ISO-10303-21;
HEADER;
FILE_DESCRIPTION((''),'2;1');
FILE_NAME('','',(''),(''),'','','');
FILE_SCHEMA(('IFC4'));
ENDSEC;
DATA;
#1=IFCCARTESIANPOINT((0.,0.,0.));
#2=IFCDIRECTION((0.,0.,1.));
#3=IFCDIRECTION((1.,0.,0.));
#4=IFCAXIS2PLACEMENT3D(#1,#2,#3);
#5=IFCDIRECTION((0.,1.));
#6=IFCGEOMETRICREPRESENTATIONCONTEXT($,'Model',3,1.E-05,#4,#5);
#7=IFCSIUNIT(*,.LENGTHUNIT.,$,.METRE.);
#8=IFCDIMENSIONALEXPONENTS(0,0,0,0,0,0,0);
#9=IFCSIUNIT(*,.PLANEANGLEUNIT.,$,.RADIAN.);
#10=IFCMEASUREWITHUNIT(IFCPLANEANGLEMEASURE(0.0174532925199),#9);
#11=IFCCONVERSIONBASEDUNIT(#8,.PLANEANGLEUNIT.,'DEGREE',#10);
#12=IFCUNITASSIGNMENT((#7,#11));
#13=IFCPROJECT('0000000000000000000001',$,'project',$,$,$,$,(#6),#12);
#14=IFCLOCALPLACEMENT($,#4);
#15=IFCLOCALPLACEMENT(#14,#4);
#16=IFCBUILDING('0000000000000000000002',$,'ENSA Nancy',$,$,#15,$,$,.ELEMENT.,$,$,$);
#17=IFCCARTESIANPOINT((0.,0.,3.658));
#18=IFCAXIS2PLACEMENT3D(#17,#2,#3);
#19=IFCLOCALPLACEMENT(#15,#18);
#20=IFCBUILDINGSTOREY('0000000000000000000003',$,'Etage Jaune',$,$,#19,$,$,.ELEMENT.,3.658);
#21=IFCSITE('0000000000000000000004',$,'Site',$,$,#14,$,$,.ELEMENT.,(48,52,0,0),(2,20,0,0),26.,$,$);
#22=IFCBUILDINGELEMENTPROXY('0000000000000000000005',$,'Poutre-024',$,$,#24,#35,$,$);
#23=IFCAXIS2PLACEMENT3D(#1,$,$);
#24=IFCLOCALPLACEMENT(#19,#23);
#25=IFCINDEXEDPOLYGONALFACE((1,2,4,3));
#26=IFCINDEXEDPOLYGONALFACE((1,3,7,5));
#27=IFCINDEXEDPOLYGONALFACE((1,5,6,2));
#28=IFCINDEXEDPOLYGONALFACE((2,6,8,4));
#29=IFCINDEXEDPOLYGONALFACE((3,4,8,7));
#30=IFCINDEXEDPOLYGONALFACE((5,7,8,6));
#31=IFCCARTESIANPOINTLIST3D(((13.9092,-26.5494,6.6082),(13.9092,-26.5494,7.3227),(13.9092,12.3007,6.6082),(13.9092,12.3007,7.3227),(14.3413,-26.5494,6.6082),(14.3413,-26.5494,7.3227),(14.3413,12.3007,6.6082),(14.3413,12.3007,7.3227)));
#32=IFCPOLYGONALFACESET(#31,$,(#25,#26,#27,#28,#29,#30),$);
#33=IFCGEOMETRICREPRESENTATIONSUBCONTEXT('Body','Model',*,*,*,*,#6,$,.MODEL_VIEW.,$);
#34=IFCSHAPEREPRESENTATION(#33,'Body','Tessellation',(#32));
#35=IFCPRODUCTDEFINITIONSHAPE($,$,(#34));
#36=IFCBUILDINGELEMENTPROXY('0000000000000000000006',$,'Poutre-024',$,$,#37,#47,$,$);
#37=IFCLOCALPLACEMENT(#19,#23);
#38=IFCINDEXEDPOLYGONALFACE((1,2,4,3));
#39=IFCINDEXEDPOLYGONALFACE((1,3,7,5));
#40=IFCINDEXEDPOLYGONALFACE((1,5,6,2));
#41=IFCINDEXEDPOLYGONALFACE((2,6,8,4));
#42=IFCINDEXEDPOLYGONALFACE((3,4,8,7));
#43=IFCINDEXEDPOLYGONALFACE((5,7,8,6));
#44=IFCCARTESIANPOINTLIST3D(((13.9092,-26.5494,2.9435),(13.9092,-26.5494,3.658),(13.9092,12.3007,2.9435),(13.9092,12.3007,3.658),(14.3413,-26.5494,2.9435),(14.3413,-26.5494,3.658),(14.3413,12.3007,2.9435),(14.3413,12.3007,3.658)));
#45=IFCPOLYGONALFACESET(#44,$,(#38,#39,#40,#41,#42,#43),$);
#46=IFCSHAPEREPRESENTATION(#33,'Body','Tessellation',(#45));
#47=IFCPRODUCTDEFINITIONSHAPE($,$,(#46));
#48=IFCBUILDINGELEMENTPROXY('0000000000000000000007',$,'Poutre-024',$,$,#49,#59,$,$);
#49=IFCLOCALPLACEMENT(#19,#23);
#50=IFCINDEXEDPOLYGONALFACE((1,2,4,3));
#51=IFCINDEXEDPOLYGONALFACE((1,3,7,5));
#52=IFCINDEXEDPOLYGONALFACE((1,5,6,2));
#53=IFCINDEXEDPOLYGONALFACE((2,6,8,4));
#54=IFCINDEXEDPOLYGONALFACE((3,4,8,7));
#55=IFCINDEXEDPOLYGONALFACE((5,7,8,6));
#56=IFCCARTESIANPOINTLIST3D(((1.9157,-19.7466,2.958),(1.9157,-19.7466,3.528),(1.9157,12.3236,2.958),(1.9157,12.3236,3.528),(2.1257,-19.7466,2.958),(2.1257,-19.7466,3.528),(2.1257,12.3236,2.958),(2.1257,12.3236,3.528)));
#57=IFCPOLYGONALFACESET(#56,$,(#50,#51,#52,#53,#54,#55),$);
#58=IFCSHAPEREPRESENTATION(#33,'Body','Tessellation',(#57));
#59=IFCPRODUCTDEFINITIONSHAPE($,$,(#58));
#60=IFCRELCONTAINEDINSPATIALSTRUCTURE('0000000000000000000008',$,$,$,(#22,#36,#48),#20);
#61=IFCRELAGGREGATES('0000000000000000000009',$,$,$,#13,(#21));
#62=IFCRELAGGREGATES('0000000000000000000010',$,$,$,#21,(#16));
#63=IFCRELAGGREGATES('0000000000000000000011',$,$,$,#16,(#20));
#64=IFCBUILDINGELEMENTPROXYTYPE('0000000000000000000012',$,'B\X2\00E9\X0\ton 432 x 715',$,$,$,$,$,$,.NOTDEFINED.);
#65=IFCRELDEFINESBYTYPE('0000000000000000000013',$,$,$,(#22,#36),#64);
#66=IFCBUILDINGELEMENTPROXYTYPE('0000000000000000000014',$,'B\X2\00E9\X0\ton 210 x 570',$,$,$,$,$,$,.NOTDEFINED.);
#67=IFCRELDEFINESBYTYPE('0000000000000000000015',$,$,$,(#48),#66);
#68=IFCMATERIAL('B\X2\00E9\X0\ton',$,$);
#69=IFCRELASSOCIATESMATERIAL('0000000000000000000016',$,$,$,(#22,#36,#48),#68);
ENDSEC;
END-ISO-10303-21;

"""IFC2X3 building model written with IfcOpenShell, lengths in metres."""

from ifc_helpers import new_model, entity, si_unit, converted_unit, direction, frame, frame_2d, origin_with_axes, place, context, subcontext, project, spatial, rectangle, extrude, material, type_object, element, save


model = new_model("IFC2X3")

# Units and contexts
model_context = context("Model", 3, precision=1e-05, world=origin_with_axes(), true_north=direction((0.0, 1.0)))
body_context = subcontext(model_context, "Body", "Model", "MODEL_VIEW")
ifc_project = project(units=[si_unit("LENGTHUNIT", "METRE"), converted_unit("PLANEANGLEUNIT", "DEGREE", entity("IfcPlaneAngleMeasure", 0.0174532925199), si_unit("PLANEANGLEUNIT", "RADIAN"), dimensions=[0, 0, 0, 0, 0, 0, 0])], contexts=[model_context])

# Site, building, storey
site_placement = place(None, origin_with_axes())
site = spatial("IfcSite", under=ifc_project, at=site_placement, Name="Site", CompositionType="ELEMENT", RefLatitude=(48, 52, 0, 0), RefLongitude=(2, 20, 0, 0), RefElevation=26.0)
building_placement = place(site_placement, origin_with_axes())
building = spatial("IfcBuilding", under=site, at=building_placement, Name="ENSA Nancy", CompositionType="ELEMENT")
storey_placement = place(building_placement, frame((0.0, 0.0, 3.658), z_axis=(0.0, 0.0, 1.0), x_axis=(1.0, 0.0, 0.0)))
storey = spatial("IfcBuildingStorey", under=building, at=storey_placement, Name="Etage Jaune", CompositionType="ELEMENT", Elevation=3.658)

# Building element proxies
ifc_material_1 = material(Name="Béton")
building_element_proxy_type_1 = type_object("IfcBuildingElementProxyType", Name="Béton 432 x 715", PredefinedType="NOTDEFINED")
for number, where, z_axis, x_axis, name in (
    (1, (14.1252, -26.5494, 7.3227), (0.0, 0.0, 1.0), (1.0, 0.0, 0.0), "Poutre-024"),
    (2, (14.1252, -26.5494, 3.658), (0.0, 0.0, 1.0), (1.0, 0.0, 0.0), "Poutre-024"),
):
    element("IfcBuildingElementProxy", number, at=place(storey_placement, frame(where, z_axis=z_axis, x_axis=x_axis)), inside=storey, type_object=building_element_proxy_type_1, material=ifc_material_1, Name=name, context=body_context, shape_type="SweptSolid", body=[
        extrude(rectangle(XDim=0.7145, YDim=0.4321, at=frame_2d((-0.3573, 0.0), x_axis=(1.0, 0.0))), frame((0.0, 0.0, 0.0), z_axis=(0.0, 1.0, 0.0), x_axis=(0.0, 0.0, 1.0)), (0.0, 0.0, 1.0), 38.8501),
    ])
building_element_proxy_type_2 = type_object("IfcBuildingElementProxyType", Name="Béton 210 x 570", PredefinedType="NOTDEFINED")
proxy_1_placement = place(storey_placement, frame((2.0207, -19.7466, 3.528), z_axis=(0.0, 0.0, 1.0), x_axis=(1.0, 0.0, 0.0)))
element("IfcBuildingElementProxy", 3, at=proxy_1_placement, inside=storey, type_object=building_element_proxy_type_2, material=ifc_material_1, Name="Poutre-024", context=body_context, shape_type="SweptSolid", body=[
    extrude(rectangle(XDim=0.57, YDim=0.21, at=frame_2d((-0.285, 0.0), x_axis=(1.0, 0.0))), frame((0.0, 0.0, 0.0), z_axis=(0.0, 1.0, 0.0), x_axis=(0.0, 0.0, 1.0)), (0.0, 0.0, 1.0), 32.0702),
])

save(model, "model.ifc")
